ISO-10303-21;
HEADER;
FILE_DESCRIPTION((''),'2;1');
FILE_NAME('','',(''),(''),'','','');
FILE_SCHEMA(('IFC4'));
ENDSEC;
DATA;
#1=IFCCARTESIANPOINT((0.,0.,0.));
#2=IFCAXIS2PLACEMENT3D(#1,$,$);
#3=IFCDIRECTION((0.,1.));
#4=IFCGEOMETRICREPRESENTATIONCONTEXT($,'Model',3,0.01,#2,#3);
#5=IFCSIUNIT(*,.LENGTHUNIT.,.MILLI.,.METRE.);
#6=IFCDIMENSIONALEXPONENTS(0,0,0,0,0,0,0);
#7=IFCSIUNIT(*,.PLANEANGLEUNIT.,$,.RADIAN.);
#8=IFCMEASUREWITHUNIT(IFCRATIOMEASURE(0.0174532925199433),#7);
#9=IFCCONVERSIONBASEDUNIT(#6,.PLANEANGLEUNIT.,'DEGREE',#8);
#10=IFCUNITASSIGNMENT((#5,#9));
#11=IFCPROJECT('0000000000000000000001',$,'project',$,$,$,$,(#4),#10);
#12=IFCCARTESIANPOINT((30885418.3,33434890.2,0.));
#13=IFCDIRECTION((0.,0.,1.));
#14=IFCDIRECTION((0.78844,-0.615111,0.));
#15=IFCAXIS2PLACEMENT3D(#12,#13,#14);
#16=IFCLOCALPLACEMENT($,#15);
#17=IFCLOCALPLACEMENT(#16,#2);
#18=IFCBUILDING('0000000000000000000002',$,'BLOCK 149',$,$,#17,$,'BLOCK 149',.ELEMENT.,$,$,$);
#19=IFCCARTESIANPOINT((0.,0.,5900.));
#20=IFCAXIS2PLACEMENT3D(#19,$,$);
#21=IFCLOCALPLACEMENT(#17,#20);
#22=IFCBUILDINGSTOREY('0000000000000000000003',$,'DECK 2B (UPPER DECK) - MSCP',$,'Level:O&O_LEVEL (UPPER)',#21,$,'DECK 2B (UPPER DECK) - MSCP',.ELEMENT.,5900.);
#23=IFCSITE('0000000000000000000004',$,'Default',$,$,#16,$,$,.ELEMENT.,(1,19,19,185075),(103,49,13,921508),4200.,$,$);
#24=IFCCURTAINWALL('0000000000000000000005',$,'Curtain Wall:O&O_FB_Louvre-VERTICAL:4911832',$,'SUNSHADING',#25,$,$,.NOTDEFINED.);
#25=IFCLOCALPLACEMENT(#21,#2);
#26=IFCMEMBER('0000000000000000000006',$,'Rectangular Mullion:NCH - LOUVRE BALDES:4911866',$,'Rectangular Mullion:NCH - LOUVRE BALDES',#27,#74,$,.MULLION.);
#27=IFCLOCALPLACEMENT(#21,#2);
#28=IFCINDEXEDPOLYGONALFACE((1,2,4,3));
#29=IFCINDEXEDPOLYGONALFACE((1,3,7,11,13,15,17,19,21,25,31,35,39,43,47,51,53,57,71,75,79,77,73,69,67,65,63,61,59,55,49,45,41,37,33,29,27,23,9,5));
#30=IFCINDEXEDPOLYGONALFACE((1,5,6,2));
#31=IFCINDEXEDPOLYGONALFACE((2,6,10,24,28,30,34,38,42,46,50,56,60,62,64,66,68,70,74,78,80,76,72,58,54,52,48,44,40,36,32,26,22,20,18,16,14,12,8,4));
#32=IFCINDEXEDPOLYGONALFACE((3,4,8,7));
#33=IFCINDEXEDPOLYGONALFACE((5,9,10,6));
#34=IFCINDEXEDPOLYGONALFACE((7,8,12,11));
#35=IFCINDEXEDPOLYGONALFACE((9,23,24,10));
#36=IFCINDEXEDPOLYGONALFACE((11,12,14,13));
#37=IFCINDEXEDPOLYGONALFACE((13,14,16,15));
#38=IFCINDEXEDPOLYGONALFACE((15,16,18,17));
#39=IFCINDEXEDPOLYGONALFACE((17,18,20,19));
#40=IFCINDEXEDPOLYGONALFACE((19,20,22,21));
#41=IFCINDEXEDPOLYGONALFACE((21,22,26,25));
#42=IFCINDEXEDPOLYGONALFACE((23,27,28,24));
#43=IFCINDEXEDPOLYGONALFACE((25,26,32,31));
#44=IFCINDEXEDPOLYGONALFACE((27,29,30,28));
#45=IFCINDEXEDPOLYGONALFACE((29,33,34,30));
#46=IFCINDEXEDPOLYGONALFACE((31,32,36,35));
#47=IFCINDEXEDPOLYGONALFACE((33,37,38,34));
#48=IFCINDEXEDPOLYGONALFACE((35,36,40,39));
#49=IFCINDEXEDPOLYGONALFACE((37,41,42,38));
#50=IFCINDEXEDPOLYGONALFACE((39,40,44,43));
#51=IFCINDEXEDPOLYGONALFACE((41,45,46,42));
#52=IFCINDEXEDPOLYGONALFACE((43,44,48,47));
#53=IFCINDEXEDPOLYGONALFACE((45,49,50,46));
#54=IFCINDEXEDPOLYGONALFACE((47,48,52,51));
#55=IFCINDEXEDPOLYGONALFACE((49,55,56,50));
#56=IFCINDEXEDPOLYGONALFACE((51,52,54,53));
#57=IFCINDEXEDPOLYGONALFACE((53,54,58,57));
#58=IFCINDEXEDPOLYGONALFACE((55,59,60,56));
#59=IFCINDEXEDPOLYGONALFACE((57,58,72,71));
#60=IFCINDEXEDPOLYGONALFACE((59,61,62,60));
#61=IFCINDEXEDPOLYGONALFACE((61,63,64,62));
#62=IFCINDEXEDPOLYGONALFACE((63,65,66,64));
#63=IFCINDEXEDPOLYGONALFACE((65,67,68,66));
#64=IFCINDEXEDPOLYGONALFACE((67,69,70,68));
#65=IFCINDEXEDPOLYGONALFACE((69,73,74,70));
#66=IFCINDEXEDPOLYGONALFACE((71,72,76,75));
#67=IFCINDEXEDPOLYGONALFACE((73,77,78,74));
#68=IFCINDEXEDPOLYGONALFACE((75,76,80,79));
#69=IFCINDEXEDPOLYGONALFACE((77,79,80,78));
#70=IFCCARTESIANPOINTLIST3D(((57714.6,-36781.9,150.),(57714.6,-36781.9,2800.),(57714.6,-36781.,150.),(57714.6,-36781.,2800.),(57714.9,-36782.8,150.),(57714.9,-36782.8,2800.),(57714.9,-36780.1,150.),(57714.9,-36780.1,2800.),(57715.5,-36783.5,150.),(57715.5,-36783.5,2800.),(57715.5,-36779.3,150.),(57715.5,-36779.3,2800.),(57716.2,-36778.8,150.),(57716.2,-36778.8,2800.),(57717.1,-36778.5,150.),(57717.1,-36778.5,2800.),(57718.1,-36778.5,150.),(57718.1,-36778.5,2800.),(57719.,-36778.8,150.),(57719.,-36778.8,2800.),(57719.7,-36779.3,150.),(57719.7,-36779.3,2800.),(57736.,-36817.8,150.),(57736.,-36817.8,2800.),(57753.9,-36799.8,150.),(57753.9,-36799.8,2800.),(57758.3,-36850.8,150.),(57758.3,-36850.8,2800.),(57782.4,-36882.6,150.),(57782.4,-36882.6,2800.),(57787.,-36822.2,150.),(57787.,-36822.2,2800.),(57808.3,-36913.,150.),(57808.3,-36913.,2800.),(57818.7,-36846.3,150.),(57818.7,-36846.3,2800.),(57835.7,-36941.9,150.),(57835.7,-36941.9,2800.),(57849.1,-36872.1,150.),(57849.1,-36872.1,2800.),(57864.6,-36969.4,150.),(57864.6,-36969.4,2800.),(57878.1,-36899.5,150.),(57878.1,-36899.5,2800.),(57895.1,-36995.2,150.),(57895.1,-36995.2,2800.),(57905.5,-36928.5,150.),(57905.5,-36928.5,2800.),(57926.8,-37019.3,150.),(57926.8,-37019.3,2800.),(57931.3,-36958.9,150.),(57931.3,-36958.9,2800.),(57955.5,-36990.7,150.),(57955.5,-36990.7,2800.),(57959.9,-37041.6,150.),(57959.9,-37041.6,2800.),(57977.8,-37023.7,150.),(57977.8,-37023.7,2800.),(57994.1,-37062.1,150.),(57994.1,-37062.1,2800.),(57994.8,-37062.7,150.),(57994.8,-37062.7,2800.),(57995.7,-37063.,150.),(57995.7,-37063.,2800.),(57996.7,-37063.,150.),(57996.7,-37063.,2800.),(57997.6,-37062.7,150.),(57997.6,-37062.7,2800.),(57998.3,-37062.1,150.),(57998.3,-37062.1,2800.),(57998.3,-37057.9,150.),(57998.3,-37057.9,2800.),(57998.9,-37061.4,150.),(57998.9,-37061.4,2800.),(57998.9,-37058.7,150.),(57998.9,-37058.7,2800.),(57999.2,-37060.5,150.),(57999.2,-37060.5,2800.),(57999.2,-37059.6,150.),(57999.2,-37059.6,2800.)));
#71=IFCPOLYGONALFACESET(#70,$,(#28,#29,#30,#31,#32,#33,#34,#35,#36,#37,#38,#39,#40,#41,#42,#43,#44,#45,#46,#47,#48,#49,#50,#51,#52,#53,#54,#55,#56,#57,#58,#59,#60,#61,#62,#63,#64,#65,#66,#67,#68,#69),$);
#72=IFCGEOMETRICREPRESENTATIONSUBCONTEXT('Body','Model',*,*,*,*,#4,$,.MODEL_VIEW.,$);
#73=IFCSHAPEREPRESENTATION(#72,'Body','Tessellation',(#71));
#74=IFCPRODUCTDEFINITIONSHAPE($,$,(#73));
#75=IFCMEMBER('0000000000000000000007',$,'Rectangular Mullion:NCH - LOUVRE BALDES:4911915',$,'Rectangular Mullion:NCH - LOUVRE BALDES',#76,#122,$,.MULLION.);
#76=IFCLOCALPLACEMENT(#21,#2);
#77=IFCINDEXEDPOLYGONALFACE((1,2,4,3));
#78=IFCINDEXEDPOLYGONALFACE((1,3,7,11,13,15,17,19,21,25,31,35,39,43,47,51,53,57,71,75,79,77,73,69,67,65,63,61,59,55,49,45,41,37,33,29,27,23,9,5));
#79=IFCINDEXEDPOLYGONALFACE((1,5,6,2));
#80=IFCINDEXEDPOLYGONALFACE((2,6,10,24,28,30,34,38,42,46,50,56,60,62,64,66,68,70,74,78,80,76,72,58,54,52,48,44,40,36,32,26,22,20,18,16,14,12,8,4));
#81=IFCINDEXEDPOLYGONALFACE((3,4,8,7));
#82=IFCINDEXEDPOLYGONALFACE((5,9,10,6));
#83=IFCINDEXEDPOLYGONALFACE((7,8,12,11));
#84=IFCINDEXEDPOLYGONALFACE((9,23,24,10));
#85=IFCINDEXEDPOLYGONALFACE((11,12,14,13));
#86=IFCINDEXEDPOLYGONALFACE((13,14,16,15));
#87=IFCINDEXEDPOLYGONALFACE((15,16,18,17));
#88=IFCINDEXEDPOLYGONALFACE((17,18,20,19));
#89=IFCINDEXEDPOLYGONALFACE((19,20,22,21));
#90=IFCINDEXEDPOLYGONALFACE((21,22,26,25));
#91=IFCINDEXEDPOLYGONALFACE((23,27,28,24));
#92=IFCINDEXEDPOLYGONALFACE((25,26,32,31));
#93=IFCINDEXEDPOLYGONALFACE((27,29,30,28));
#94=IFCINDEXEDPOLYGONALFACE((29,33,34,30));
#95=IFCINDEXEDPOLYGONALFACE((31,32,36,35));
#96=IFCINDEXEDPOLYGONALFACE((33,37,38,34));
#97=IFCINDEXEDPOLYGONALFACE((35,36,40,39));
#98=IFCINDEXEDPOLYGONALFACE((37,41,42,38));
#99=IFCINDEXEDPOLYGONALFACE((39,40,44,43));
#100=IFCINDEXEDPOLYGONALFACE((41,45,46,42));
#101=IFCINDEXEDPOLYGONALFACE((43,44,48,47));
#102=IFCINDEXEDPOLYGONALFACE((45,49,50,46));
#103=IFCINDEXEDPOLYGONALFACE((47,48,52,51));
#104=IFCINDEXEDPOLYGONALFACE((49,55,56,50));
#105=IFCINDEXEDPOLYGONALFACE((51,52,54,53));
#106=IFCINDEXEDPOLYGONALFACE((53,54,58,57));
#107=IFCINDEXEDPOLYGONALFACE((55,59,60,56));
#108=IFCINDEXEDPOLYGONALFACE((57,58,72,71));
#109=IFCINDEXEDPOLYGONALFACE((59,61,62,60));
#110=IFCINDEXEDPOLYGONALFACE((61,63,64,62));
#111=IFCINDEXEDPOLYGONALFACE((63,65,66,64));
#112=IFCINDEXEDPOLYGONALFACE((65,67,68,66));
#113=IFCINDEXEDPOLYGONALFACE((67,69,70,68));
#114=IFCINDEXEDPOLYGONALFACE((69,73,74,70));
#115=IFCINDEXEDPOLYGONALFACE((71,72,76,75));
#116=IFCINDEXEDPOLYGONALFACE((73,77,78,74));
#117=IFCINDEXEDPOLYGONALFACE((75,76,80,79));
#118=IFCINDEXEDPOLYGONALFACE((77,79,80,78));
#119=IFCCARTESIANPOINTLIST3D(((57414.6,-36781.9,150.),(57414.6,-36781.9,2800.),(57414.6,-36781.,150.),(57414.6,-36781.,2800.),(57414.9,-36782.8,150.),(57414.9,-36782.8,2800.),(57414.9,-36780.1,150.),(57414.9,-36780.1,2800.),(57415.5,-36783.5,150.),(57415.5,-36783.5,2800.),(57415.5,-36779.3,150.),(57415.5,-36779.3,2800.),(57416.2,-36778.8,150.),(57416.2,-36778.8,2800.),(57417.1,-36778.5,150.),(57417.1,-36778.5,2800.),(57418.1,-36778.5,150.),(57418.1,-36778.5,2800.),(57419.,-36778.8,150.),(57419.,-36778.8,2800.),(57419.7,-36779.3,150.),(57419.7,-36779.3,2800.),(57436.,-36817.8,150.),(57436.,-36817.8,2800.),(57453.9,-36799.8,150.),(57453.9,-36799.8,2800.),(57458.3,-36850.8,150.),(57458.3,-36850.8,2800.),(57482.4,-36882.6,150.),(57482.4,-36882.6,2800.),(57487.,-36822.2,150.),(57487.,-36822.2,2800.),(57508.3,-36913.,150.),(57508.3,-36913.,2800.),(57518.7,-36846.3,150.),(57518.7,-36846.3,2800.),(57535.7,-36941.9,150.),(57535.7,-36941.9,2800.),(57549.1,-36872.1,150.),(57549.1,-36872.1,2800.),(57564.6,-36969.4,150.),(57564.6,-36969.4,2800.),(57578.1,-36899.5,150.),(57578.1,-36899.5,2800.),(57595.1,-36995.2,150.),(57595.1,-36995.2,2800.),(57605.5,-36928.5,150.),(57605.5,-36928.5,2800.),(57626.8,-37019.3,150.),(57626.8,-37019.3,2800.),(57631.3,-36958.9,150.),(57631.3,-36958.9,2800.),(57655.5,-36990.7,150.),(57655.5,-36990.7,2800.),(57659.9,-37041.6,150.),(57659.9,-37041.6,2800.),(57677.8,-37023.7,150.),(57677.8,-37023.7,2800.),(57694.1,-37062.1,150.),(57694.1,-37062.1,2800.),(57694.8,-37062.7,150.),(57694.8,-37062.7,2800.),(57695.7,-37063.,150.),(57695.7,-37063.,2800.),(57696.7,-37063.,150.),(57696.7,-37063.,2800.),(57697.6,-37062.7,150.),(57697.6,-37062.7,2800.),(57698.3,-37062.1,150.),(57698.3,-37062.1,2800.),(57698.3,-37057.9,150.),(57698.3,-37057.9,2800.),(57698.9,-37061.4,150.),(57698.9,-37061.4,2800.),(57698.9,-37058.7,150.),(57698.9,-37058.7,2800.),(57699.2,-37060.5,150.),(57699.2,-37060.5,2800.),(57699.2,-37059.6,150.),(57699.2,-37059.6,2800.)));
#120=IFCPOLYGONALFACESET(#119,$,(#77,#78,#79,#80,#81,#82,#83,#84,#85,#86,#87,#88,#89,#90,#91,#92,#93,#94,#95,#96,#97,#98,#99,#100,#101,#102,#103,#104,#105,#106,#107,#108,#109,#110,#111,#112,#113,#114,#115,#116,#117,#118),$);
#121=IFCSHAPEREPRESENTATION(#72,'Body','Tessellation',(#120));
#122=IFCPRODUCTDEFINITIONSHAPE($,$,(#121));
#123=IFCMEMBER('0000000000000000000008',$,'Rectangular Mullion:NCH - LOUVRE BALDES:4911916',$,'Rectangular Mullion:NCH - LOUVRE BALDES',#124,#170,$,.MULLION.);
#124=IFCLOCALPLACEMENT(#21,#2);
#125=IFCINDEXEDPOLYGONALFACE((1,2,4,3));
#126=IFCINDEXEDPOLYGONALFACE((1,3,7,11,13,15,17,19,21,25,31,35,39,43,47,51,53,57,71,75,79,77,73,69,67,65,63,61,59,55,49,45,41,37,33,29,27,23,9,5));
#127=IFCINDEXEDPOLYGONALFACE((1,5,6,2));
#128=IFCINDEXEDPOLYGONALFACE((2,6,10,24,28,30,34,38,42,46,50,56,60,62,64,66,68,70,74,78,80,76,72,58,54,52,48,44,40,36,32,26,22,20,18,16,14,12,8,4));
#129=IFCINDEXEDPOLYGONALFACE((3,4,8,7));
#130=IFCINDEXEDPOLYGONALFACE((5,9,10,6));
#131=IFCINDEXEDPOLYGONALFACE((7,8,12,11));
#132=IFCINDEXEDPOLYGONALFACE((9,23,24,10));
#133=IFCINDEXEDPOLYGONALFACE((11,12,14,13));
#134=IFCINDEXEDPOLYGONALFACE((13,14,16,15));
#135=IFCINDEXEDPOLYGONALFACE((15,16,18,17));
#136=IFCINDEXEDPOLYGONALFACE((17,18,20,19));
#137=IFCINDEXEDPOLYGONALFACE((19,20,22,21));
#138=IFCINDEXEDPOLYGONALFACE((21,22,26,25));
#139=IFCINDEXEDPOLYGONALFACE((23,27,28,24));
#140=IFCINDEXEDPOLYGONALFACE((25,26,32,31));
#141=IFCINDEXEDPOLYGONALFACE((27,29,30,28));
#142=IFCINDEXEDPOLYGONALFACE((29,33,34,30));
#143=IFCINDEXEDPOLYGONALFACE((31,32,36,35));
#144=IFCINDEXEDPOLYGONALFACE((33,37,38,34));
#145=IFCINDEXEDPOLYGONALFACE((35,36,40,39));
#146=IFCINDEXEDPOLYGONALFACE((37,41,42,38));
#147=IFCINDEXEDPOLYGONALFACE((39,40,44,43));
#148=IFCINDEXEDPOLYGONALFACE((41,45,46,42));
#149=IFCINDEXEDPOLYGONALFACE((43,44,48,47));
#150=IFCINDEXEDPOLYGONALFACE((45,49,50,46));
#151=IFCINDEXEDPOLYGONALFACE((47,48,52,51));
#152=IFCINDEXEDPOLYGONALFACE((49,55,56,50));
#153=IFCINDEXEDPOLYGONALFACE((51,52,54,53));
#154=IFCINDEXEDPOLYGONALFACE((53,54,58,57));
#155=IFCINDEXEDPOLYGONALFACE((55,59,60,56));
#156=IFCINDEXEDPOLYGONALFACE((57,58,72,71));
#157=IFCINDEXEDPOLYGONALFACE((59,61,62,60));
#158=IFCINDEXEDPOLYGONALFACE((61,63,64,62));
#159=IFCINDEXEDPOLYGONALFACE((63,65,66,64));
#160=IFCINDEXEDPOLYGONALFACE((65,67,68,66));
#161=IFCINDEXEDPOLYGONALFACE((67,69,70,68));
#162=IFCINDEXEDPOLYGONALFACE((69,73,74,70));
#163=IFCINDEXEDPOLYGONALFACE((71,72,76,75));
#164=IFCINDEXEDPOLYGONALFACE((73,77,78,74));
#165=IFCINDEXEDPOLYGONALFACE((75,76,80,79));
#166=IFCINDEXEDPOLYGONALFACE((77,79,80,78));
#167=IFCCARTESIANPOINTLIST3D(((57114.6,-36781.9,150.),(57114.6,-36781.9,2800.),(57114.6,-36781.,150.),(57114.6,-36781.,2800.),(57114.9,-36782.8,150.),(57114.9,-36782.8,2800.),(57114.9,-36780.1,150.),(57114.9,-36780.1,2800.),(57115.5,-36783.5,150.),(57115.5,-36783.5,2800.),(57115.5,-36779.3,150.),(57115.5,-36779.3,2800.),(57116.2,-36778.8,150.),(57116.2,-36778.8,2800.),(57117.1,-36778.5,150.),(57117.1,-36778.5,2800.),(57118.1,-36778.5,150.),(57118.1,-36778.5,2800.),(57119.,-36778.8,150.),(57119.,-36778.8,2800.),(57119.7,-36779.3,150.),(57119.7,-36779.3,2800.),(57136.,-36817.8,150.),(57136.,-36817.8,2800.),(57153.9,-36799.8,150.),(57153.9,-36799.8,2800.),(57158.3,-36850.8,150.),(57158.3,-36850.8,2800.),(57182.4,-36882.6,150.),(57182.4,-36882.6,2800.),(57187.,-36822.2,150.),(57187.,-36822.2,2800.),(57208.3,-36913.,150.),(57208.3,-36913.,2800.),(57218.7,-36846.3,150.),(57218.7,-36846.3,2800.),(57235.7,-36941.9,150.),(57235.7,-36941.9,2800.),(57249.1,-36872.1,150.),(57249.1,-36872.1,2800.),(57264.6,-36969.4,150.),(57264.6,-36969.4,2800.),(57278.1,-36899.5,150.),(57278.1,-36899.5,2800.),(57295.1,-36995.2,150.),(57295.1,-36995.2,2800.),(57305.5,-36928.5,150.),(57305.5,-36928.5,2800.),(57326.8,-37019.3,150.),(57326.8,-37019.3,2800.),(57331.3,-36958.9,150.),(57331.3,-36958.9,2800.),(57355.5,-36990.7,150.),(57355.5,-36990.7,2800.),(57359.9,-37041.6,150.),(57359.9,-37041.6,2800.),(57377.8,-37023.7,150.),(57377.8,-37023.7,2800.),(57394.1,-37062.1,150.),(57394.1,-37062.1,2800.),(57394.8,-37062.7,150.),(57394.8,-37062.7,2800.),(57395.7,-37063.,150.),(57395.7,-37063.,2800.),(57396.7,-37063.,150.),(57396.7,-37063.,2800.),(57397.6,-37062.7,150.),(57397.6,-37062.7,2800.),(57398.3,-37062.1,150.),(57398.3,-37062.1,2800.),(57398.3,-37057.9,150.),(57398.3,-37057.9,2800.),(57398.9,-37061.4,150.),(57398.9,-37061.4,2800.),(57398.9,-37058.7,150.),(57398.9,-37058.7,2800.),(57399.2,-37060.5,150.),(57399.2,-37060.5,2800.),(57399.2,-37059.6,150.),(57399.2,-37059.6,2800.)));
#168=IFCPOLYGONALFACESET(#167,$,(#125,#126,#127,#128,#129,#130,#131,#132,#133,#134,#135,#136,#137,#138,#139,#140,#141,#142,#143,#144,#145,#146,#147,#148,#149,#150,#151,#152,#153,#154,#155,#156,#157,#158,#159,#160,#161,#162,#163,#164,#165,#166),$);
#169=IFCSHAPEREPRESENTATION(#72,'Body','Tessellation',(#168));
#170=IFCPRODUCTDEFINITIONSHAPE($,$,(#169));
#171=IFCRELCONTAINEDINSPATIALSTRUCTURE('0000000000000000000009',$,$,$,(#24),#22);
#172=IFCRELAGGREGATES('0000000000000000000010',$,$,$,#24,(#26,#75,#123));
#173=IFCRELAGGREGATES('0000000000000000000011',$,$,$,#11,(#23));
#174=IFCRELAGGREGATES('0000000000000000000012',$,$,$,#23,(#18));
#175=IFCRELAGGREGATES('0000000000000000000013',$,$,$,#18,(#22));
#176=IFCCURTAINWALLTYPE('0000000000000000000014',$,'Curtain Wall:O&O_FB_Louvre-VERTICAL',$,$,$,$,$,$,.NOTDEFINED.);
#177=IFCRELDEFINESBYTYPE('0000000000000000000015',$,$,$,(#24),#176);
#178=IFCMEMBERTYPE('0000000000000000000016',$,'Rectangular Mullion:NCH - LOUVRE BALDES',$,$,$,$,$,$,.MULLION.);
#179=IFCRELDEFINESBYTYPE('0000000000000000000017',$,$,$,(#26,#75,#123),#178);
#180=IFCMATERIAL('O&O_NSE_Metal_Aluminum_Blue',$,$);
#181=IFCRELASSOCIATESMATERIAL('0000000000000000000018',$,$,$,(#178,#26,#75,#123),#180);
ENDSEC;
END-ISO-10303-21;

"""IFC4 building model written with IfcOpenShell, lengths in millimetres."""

from ifc_helpers import new_model, entity, si_unit, converted_unit, direction, frame, origin, place, context, subcontext, project, spatial, indexed_curve, outline, extrude, source, transform, mapped, material, type_object, type_shapes, element, aggregate, save


model = new_model("IFC4")

# Units and contexts
model_context = context("Model", 3, precision=0.01, world=origin(), true_north=direction((0.0, 1.0)))
body_context = subcontext(model_context, "Body", "Model", "MODEL_VIEW")
ifc_project = project(units=[si_unit("LENGTHUNIT", "METRE", prefix="MILLI"), converted_unit("PLANEANGLEUNIT", "DEGREE", entity("IfcRatioMeasure", 0.0174532925199433), si_unit("PLANEANGLEUNIT", "RADIAN"), dimensions=[0, 0, 0, 0, 0, 0, 0])], contexts=[model_context])

# Site, building, storey
site_placement = place(None, frame((30885418.3, 33434890.2, 0.0), z_axis=(0.0, 0.0, 1.0), x_axis=(0.78844, -0.615111, 0.0)))
site = spatial("IfcSite", under=ifc_project, at=site_placement, Name="Default", CompositionType="ELEMENT", RefLatitude=(1, 19, 19, 185075), RefLongitude=(103, 49, 13, 921508), RefElevation=4200.0)
building_placement = place(site_placement, origin())
building = spatial("IfcBuilding", under=site, at=building_placement, Name="BLOCK 149", LongName="BLOCK 149", CompositionType="ELEMENT")
storey_placement = place(building_placement, frame((0.0, 0.0, 5900.0)))
storey = spatial("IfcBuildingStorey", under=building, at=storey_placement, Name="DECK 2B (UPPER DECK) - MSCP", ObjectType="Level:O&O_LEVEL (UPPER)", LongName="DECK 2B (UPPER DECK) - MSCP", CompositionType="ELEMENT", Elevation=5900.0)

# Curtain wall, members
curtain_wall_type = type_object("IfcCurtainWallType", Name="Curtain Wall:O&O_FB_Louvre-VERTICAL", PredefinedType="NOTDEFINED")
curtain_wall_placement = place(storey_placement, frame((0.0, 0.0, -5900.0)))
curtain_wall = element("IfcCurtainWall", 1, at=curtain_wall_placement, inside=storey, type_object=curtain_wall_type, Name="Curtain Wall:O&O_FB_Louvre-VERTICAL:4911832", ObjectType="SUNSHADING", PredefinedType="NOTDEFINED")
placement = place(building_placement, origin())
ifc_material_1 = material(Name="O&O_NSE_Metal_Aluminum_Blue")
member_type_1 = type_object("IfcMemberType", Name="Rectangular Mullion:NCH - LOUVRE BALDES", PredefinedType="MULLION", material=ifc_material_1)
shared_shape_1 = source(origin(), body_context, "Body", "SweptSolid", [
    extrude(outline(indexed_curve([(55.9, -188.9), (54.8, -149.1), (51.6, -109.3), (46.1, -69.8), (38.6, -30.6), (28.9, 8.1), (17.1, 46.2), (3.3, 83.6), (-12.6, 120.2), (-30.4, 155.9), (-50.1, 190.5), (-50.5, 191.4), (-51.1, 192.1), (-52.0, 192.5), (-52.9, 192.7), (-53.8, 192.6), (-54.7, 192.2), (-55.4, 191.6), (-55.8, 190.8), (-56.0, 189.9), (-55.9, 188.9), (-54.8, 149.1), (-51.6, 109.3), (-46.1, 69.8), (-38.6, 30.6), (-28.9, -8.1), (-17.1, -46.2), (-3.3, -83.6), (12.6, -120.2), (30.4, -155.9), (50.1, -190.5), (50.5, -191.4), (51.1, -192.1), (52.0, -192.5), (52.9, -192.7), (53.8, -192.6), (54.7, -192.2), (55.4, -191.6), (55.8, -190.8), (56.0, -189.9), (55.9, -188.9)], self_intersect=False)), frame((0.0, 0.0, -2650.0), z_axis=(0.0, 0.0, 1.0), x_axis=(0.490779, -0.871284, 0.0)), (0.0, 0.0, 1.0), 2650.0),
])
type_shapes(member_type_1, [shared_shape_1])
member_1_placement = place(placement, frame((57856.9, -36920.7, 6050.0), z_axis=(0.0, 0.0, -1.0), x_axis=(-1.0, 0.0, 0.0)))
member_1 = element("IfcMember", 2, at=member_1_placement, type_object=member_type_1, material=ifc_material_1, Name="Rectangular Mullion:NCH - LOUVRE BALDES:4911866", ObjectType="Rectangular Mullion:NCH - LOUVRE BALDES", PredefinedType="MULLION", context=body_context, shape_type="MappedRepresentation", body=[
    mapped(shared_shape_1, transform((0.0, 0.0, 0.0), scale=1.0)),
])
member_2_placement = place(placement, frame((57556.9, -36920.7, 6050.0), z_axis=(0.0, 0.0, -1.0), x_axis=(-1.0, 0.0, 0.0)))
member_2 = element("IfcMember", 3, at=member_2_placement, type_object=member_type_1, material=ifc_material_1, Name="Rectangular Mullion:NCH - LOUVRE BALDES:4911915", ObjectType="Rectangular Mullion:NCH - LOUVRE BALDES", PredefinedType="MULLION", context=body_context, shape_type="MappedRepresentation", body=[
    mapped(shared_shape_1, transform((0.0, 0.0, 0.0), scale=1.0)),
])
member_3_placement = place(placement, frame((57256.9, -36920.7, 6050.0), z_axis=(0.0, 0.0, -1.0), x_axis=(-1.0, 0.0, 0.0)))
member_3 = element("IfcMember", 4, at=member_3_placement, type_object=member_type_1, material=ifc_material_1, Name="Rectangular Mullion:NCH - LOUVRE BALDES:4911916", ObjectType="Rectangular Mullion:NCH - LOUVRE BALDES", PredefinedType="MULLION", context=body_context, shape_type="MappedRepresentation", body=[
    mapped(shared_shape_1, transform((0.0, 0.0, 0.0), scale=1.0)),
])
aggregate(curtain_wall, [member_1, member_2, member_3])

save(model, "model.ifc")
